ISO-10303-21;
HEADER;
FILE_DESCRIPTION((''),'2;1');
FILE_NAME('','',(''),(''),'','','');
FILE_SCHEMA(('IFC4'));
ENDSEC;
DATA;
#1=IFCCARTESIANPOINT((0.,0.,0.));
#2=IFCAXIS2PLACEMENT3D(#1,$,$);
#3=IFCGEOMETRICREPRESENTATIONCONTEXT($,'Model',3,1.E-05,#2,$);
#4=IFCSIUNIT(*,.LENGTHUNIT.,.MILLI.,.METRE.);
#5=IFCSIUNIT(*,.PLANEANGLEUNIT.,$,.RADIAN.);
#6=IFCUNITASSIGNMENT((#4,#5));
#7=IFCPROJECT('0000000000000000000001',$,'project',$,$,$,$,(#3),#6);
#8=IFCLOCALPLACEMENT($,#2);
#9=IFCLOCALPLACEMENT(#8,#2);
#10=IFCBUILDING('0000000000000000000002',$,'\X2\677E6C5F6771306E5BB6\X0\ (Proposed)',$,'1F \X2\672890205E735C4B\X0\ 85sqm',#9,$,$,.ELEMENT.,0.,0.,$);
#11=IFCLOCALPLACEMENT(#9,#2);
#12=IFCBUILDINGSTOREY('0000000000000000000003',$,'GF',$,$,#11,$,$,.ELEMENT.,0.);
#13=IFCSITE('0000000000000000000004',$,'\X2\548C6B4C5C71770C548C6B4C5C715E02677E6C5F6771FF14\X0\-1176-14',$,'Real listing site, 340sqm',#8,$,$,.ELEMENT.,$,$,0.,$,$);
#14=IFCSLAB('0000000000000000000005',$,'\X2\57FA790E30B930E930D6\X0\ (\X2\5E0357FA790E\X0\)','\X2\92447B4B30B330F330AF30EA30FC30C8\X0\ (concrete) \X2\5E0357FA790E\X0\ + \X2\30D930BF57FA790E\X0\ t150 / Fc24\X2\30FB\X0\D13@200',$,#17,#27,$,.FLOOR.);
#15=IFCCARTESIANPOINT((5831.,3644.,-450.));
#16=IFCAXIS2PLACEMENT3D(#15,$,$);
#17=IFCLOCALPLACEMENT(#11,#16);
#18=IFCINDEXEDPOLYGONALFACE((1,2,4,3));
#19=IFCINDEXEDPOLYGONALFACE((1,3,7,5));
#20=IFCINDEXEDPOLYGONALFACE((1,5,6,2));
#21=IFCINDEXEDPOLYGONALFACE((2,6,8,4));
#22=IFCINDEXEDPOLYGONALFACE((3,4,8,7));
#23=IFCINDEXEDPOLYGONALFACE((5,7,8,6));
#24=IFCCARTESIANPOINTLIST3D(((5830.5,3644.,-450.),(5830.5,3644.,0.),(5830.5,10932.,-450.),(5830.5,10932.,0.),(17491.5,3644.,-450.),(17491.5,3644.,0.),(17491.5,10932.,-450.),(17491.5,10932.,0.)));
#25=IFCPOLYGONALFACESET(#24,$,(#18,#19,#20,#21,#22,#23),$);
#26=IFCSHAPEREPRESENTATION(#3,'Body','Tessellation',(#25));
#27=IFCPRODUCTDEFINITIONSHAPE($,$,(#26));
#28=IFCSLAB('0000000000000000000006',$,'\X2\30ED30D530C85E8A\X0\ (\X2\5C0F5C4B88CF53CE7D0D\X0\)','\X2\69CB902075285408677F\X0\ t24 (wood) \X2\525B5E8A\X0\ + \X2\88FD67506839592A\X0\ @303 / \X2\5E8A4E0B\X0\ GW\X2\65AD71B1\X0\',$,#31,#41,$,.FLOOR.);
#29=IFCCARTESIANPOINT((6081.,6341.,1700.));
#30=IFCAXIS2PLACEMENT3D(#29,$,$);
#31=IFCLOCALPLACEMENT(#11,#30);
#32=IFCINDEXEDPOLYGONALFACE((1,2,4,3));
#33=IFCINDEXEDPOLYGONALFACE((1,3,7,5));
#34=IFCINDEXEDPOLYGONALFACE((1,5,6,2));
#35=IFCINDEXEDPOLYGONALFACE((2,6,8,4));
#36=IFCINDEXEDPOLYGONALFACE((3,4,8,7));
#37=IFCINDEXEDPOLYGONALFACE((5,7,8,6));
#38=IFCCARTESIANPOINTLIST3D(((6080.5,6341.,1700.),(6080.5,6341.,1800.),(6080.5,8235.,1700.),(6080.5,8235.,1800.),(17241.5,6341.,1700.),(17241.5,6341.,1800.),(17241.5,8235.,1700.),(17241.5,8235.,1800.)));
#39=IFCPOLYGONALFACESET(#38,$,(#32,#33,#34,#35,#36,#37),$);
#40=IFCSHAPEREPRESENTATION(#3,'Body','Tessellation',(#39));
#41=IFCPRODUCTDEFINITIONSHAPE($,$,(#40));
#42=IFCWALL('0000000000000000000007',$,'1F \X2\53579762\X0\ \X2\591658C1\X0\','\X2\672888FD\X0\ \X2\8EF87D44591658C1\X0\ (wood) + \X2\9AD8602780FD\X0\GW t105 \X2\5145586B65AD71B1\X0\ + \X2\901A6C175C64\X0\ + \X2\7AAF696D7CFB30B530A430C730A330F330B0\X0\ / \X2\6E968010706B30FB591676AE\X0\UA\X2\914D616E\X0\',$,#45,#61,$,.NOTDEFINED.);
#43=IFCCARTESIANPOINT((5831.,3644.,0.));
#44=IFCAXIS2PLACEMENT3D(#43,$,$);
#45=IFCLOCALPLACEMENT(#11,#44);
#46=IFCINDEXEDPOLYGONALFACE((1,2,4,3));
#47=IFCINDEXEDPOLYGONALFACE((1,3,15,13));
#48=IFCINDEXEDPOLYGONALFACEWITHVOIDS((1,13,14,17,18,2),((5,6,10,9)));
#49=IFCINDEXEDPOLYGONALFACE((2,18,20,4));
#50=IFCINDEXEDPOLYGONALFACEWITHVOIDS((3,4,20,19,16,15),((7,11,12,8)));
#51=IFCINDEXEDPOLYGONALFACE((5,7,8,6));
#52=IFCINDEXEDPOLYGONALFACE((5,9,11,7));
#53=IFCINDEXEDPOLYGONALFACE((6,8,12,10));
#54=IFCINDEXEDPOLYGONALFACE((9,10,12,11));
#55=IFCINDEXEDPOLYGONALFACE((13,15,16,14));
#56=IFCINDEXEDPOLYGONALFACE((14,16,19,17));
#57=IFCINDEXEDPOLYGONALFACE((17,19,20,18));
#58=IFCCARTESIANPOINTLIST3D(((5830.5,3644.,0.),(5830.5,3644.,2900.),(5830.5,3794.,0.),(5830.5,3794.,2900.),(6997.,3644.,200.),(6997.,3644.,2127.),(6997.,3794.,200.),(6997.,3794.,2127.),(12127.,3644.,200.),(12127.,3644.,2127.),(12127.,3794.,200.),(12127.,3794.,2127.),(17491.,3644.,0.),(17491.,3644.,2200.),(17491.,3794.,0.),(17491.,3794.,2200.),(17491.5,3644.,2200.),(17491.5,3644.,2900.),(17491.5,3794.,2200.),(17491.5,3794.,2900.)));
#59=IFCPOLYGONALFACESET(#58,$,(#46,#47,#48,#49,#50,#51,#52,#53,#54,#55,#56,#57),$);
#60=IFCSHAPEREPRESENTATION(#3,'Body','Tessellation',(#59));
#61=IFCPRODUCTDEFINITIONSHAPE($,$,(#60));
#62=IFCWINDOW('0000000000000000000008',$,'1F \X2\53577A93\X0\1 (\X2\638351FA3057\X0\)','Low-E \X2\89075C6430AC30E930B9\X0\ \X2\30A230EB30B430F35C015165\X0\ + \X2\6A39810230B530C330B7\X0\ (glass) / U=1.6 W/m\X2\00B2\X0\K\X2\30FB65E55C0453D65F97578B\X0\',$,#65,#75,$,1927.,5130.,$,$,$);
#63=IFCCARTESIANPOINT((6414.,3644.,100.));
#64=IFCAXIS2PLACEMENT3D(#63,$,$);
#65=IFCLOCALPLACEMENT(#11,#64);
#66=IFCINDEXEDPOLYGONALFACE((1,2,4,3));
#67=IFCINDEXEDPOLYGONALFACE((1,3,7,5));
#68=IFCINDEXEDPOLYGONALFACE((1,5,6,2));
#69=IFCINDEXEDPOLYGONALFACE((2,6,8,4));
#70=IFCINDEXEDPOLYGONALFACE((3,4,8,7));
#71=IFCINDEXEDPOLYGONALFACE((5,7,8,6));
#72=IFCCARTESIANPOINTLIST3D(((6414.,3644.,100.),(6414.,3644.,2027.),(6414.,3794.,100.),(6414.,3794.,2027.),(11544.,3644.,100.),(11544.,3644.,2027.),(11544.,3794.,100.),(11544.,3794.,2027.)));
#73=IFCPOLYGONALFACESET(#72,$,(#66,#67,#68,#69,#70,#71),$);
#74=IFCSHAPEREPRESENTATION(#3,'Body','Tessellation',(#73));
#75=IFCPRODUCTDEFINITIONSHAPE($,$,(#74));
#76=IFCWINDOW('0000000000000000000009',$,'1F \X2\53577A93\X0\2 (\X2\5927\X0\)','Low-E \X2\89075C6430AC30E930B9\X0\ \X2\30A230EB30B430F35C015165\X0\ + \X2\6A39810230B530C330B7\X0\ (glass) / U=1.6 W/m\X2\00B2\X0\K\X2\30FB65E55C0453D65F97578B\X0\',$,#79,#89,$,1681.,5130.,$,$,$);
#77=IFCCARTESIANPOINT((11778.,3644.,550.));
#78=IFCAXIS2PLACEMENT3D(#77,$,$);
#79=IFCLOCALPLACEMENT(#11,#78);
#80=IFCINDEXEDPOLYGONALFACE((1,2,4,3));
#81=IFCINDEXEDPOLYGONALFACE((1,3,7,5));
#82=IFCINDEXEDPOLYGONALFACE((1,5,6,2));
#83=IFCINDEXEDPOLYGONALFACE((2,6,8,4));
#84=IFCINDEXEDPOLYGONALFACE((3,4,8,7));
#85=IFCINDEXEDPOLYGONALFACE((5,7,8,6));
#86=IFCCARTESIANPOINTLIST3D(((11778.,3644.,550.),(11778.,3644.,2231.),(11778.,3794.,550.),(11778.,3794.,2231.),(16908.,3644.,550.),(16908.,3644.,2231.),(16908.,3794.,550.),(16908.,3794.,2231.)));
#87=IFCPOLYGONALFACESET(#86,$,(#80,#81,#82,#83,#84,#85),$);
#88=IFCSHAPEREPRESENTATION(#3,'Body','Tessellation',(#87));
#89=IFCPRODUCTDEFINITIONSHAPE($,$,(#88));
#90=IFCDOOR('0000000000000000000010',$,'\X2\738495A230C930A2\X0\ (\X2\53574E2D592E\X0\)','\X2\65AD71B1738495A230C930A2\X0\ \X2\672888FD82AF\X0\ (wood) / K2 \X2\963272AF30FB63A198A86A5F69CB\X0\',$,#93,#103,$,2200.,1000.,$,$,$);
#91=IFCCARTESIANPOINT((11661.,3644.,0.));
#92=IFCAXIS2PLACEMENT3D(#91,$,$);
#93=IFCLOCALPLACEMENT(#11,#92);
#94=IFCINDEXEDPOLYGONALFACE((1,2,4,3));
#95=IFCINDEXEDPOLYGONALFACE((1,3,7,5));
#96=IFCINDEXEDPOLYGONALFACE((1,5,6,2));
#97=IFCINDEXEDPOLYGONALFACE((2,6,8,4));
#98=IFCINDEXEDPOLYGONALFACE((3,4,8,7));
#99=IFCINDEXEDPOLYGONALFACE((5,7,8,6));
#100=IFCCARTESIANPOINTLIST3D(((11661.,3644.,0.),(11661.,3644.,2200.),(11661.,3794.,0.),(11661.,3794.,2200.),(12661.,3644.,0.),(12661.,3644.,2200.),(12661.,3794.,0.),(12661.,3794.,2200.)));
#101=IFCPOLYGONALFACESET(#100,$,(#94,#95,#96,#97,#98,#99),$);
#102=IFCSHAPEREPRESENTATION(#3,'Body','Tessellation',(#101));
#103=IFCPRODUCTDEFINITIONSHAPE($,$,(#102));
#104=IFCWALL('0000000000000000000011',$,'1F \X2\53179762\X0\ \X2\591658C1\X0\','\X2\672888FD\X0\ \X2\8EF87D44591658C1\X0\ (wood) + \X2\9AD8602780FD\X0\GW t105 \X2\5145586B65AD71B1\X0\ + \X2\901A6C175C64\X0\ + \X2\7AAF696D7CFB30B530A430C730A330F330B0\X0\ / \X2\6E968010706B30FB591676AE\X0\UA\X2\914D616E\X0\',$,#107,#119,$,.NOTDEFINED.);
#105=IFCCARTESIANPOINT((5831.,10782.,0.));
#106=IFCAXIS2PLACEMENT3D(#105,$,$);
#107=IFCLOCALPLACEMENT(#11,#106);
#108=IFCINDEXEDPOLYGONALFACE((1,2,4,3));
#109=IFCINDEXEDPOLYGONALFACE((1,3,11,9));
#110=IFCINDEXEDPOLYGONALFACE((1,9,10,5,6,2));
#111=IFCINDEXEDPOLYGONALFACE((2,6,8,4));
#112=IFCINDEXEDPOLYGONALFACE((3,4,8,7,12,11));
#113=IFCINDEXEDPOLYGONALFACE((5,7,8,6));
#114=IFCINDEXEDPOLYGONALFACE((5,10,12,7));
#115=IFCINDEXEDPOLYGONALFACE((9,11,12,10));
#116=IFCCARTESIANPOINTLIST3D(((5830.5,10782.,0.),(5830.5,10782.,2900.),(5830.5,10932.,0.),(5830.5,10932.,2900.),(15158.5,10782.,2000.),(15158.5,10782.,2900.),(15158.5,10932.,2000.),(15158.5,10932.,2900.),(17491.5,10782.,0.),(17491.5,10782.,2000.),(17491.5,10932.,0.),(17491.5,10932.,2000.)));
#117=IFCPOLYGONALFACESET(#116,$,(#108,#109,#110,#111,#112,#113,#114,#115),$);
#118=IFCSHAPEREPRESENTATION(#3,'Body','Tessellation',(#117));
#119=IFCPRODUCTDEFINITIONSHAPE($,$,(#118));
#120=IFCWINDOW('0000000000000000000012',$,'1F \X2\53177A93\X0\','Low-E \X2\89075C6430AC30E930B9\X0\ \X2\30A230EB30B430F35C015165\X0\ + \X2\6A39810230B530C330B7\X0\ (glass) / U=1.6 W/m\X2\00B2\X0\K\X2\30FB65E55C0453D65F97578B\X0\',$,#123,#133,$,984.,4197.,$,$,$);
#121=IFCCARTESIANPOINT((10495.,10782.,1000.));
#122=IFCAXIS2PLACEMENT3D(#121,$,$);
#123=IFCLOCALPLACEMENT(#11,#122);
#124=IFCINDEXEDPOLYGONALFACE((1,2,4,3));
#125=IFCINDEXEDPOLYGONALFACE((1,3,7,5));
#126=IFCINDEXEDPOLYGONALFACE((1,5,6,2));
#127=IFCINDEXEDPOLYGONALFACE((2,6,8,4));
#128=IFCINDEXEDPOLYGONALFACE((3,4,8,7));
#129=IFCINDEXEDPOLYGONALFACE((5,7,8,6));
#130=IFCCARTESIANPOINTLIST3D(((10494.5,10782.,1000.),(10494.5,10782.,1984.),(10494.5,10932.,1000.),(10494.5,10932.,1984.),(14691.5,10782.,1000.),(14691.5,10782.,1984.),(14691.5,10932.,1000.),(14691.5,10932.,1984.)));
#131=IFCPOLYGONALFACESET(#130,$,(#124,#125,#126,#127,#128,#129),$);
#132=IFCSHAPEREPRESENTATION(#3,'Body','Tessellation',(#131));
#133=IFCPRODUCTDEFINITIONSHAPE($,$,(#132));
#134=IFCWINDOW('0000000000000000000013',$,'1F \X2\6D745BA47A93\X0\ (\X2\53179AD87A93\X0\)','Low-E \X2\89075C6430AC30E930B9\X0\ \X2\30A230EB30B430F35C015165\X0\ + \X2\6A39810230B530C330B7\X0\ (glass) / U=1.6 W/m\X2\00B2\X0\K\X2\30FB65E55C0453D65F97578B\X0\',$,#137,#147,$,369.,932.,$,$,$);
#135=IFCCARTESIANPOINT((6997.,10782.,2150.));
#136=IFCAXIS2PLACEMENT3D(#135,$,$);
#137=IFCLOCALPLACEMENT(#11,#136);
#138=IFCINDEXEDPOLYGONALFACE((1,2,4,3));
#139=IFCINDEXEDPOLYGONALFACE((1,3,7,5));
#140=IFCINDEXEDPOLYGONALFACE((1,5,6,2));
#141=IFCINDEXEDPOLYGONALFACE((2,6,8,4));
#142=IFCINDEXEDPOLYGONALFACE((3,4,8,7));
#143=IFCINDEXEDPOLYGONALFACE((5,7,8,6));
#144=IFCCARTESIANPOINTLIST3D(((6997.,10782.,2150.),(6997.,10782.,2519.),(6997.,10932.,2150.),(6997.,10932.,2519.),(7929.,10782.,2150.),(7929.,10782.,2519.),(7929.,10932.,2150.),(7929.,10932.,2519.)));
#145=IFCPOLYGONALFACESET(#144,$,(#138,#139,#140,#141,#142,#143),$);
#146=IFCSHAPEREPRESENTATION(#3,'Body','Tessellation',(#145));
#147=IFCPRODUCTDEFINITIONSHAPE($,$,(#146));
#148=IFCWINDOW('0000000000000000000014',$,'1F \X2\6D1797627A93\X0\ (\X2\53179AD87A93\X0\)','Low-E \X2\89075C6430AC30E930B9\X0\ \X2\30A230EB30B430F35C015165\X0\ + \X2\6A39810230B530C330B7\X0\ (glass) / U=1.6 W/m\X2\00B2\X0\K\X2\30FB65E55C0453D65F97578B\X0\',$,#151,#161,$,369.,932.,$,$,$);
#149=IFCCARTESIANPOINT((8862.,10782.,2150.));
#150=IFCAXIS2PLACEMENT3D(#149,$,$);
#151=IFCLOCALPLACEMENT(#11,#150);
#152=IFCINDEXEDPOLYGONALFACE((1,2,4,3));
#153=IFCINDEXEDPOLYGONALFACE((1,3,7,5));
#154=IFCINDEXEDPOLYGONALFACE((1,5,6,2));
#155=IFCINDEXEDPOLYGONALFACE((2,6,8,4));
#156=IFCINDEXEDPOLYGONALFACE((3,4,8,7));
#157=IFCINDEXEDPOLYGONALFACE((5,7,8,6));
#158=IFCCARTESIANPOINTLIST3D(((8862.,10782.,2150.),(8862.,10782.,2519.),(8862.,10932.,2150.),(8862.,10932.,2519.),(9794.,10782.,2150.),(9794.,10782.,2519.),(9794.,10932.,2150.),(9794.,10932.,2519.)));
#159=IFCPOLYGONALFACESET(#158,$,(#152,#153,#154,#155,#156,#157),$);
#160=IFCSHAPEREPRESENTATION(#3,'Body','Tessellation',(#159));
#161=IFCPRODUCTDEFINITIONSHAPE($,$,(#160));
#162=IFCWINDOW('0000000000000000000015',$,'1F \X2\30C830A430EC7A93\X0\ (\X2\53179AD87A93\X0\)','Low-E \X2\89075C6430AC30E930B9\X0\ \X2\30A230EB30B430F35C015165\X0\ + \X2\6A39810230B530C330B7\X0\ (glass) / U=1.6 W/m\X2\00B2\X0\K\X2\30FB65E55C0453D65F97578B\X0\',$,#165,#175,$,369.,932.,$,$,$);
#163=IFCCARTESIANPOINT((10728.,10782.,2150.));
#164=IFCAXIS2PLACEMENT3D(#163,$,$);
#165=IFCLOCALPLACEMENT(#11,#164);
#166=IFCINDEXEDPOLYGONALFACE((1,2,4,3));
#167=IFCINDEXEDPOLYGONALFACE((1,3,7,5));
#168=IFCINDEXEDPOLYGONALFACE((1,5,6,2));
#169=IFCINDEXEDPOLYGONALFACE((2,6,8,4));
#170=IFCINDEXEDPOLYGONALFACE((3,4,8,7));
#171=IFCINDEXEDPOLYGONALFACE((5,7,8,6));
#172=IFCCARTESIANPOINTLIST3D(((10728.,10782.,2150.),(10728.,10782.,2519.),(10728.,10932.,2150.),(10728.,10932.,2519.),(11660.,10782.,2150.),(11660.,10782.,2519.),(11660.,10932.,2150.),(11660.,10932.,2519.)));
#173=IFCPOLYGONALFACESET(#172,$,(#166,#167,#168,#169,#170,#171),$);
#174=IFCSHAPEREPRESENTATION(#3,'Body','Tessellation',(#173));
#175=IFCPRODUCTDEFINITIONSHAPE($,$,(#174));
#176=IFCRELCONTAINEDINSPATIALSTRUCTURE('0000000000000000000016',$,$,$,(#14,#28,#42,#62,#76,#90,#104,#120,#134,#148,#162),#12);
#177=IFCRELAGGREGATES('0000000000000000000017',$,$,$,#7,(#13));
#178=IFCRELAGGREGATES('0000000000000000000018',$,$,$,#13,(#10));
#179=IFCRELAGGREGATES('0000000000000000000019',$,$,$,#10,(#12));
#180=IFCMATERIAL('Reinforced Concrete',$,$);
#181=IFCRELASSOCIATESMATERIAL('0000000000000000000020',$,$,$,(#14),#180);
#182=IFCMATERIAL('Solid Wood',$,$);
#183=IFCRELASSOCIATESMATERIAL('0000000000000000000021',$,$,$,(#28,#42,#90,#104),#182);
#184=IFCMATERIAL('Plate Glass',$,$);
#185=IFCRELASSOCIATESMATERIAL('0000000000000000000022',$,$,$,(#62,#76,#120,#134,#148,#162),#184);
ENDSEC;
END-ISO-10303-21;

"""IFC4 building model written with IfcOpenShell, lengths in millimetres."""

from ifc_helpers import new_model, si_unit, frame, frame_2d, origin, place, context, project, spatial, rectangle, extrude, material, element, fill, save


model = new_model("IFC4")

# Units and contexts
model_context = context("Model", 3, precision=1e-05, world=origin())
ifc_project = project(units=[si_unit("LENGTHUNIT", "METRE", prefix="MILLI"), si_unit("PLANEANGLEUNIT", "RADIAN")], contexts=[model_context])

# Site, building, storey
site_placement = place(None, origin())
site = spatial("IfcSite", under=ifc_project, at=site_placement, Name="和歌山県和歌山市松江東４-1176-14", ObjectType="Real listing site, 340sqm", CompositionType="ELEMENT", RefElevation=0.0)
building_placement = place(site_placement, origin())
building = spatial("IfcBuilding", under=site, at=building_placement, Name="松江東の家 (Proposed)", ObjectType="1F 木造平屋 85sqm", CompositionType="ELEMENT", ElevationOfRefHeight=0.0, ElevationOfTerrain=0.0)
storey_placement = place(building_placement, origin())
storey = spatial("IfcBuildingStorey", under=building, at=storey_placement, Name="GF", CompositionType="ELEMENT", Elevation=0.0)

# Slabs
ifc_material_1 = material(Name="Reinforced Concrete")
slab_1_placement = place(storey_placement, frame((5831.0, 3644.0, -450.0)))
element("IfcSlab", 1, at=slab_1_placement, inside=storey, material=ifc_material_1, Name="基礎スラブ (布基礎)", Description="鉄筋コンクリート (concrete) 布基礎 + ベタ基礎 t150 / Fc24・D13@200", PredefinedType="FLOOR", context=model_context, shape_type="SweptSolid", body=[
    extrude(rectangle(XDim=11661.0, YDim=7288.0, at=frame_2d((5830.0, 3644.0))), frame((5831.0, 3644.0, -450.0)), (0.0, 0.0, 1.0), 450.0),
])
ifc_material_2 = material(Name="Solid Wood")
slab_2_placement = place(storey_placement, frame((6081.0, 6341.0, 1700.0)))
element("IfcSlab", 2, at=slab_2_placement, inside=storey, material=ifc_material_2, Name="ロフト床 (小屋裏収納)", Description="構造用合板 t24 (wood) 剛床 + 製材根太 @303 / 床下 GW断熱", PredefinedType="FLOOR", context=model_context, shape_type="SweptSolid", body=[
    extrude(rectangle(XDim=11161.0, YDim=1894.0, at=frame_2d((5580.0, 947.0))), frame((6081.0, 6341.0, 1700.0)), (0.0, 0.0, 1.0), 100.0),
])

# Wall, openings, windows, door
wall_1_placement = place(storey_placement, frame((5831.0, 3644.0, 0.0)))
wall_1 = element("IfcWall", 3, at=wall_1_placement, inside=storey, material=ifc_material_2, Name="1F 南面 外壁", Description="木製 軸組外壁 (wood) + 高性能GW t105 充填断熱 + 通気層 + 窯業系サイディング / 準耐火・外皮UA配慮", PredefinedType="NOTDEFINED", context=model_context, shape_type="SweptSolid", body=[
    extrude(rectangle(XDim=11661.0, YDim=150.0, at=frame_2d((5830.0, 75.0))), frame((5831.0, 3644.0, 0.0)), (0.0, 0.0, 1.0), 2900.0),
])
opening_1_placement = place(storey_placement, frame((6414.0, 3644.0, 100.0)))
opening_1 = element("IfcOpeningElement", 4, at=opening_1_placement, cuts=wall_1, PredefinedType="NOTDEFINED", context=model_context, shape_type="SweptSolid", body=[
    extrude(rectangle(XDim=5130.0, YDim=150.0, at=frame_2d((2565.0, 75.0))), frame((6414.0, 3644.0, 100.0)), (0.0, 0.0, 1.0), 1927.0),
])
opening_2_placement = place(storey_placement, frame((11778.0, 3644.0, 550.0)))
opening_2 = element("IfcOpeningElement", 5, at=opening_2_placement, cuts=wall_1, PredefinedType="NOTDEFINED", context=model_context, shape_type="SweptSolid", body=[
    extrude(rectangle(XDim=5130.0, YDim=150.0, at=frame_2d((2565.0, 75.0))), frame((11778.0, 3644.0, 550.0)), (0.0, 0.0, 1.0), 1681.0),
])
opening_3_placement = place(storey_placement, frame((11661.0, 3644.0, 0.0)))
opening_3 = element("IfcOpeningElement", 6, at=opening_3_placement, cuts=wall_1, PredefinedType="NOTDEFINED", context=model_context, shape_type="SweptSolid", body=[
    extrude(rectangle(XDim=1000.0, YDim=150.0, at=frame_2d((500.0, 75.0))), frame((11661.0, 3644.0, 0.0)), (0.0, 0.0, 1.0), 2200.0),
])
ifc_material_3 = material(Name="Plate Glass")
window_1_placement = place(storey_placement, frame((6414.0, 3644.0, 100.0)))
window_1 = element("IfcWindow", 7, at=window_1_placement, inside=storey, material=ifc_material_3, Name="1F 南窓1 (掃出し)", Description="Low-E 複層ガラス アルゴン封入 + 樹脂サッシ (glass) / U=1.6 W/m²K・日射取得型", OverallHeight=1927.0, OverallWidth=5130.0, context=model_context, shape_type="SweptSolid", body=[
    extrude(rectangle(XDim=5130.0, YDim=150.0, at=frame_2d((2565.0, 75.0))), frame((6414.0, 3644.0, 100.0)), (0.0, 0.0, 1.0), 1927.0),
])
fill(opening_1, window_1)
window_2_placement = place(storey_placement, frame((11778.0, 3644.0, 550.0)))
window_2 = element("IfcWindow", 8, at=window_2_placement, inside=storey, material=ifc_material_3, Name="1F 南窓2 (大)", Description="Low-E 複層ガラス アルゴン封入 + 樹脂サッシ (glass) / U=1.6 W/m²K・日射取得型", OverallHeight=1681.0, OverallWidth=5130.0, context=model_context, shape_type="SweptSolid", body=[
    extrude(rectangle(XDim=5130.0, YDim=150.0, at=frame_2d((2565.0, 75.0))), frame((11778.0, 3644.0, 550.0)), (0.0, 0.0, 1.0), 1681.0),
])
fill(opening_2, window_2)
door_1_placement = place(storey_placement, frame((11661.0, 3644.0, 0.0)))
door_1 = element("IfcDoor", 9, at=door_1_placement, inside=storey, material=ifc_material_2, Name="玄関ドア (南中央)", Description="断熱玄関ドア 木製芯 (wood) / K2 防犯・採風機構", OverallHeight=2200.0, OverallWidth=1000.0, context=model_context, shape_type="SweptSolid", body=[
    extrude(rectangle(XDim=1000.0, YDim=150.0, at=frame_2d((500.0, 75.0))), frame((11661.0, 3644.0, 0.0)), (0.0, 0.0, 1.0), 2200.0),
])
fill(opening_3, door_1)

# Wall, openings, windows
wall_2_placement = place(storey_placement, frame((5831.0, 10782.0, 0.0)))
wall_2 = element("IfcWall", 10, at=wall_2_placement, inside=storey, material=ifc_material_2, Name="1F 北面 外壁", Description="木製 軸組外壁 (wood) + 高性能GW t105 充填断熱 + 通気層 + 窯業系サイディング / 準耐火・外皮UA配慮", PredefinedType="NOTDEFINED", context=model_context, shape_type="SweptSolid", body=[
    extrude(rectangle(XDim=11661.0, YDim=150.0, at=frame_2d((5830.0, 75.0))), frame((5831.0, 10782.0, 0.0)), (0.0, 0.0, 1.0), 2900.0),
])
opening_4_placement = place(storey_placement, frame((10495.0, 10782.0, 1000.0)))
opening_4 = element("IfcOpeningElement", 11, at=opening_4_placement, cuts=wall_2, PredefinedType="NOTDEFINED", context=model_context, shape_type="SweptSolid", body=[
    extrude(rectangle(XDim=4197.0, YDim=150.0, at=frame_2d((2098.0, 75.0))), frame((10495.0, 10782.0, 1000.0)), (0.0, 0.0, 1.0), 984.0),
])
opening_5_placement = place(storey_placement, frame((6997.0, 10782.0, 2150.0)))
opening_5 = element("IfcOpeningElement", 12, at=opening_5_placement, cuts=wall_2, PredefinedType="NOTDEFINED", context=model_context, shape_type="SweptSolid", body=[
    extrude(rectangle(XDim=932.0, YDim=150.0, at=frame_2d((466.0, 75.0))), frame((6997.0, 10782.0, 2150.0)), (0.0, 0.0, 1.0), 369.0),
])
opening_6_placement = place(storey_placement, frame((8862.0, 10782.0, 2150.0)))
opening_6 = element("IfcOpeningElement", 13, at=opening_6_placement, cuts=wall_2, PredefinedType="NOTDEFINED", context=model_context, shape_type="SweptSolid", body=[
    extrude(rectangle(XDim=932.0, YDim=150.0, at=frame_2d((466.0, 75.0))), frame((8862.0, 10782.0, 2150.0)), (0.0, 0.0, 1.0), 369.0),
])
opening_7_placement = place(storey_placement, frame((10728.0, 10782.0, 2150.0)))
opening_7 = element("IfcOpeningElement", 14, at=opening_7_placement, cuts=wall_2, PredefinedType="NOTDEFINED", context=model_context, shape_type="SweptSolid", body=[
    extrude(rectangle(XDim=932.0, YDim=150.0, at=frame_2d((466.0, 75.0))), frame((10728.0, 10782.0, 2150.0)), (0.0, 0.0, 1.0), 369.0),
])
window_3_placement = place(storey_placement, frame((10495.0, 10782.0, 1000.0)))
window_3 = element("IfcWindow", 15, at=window_3_placement, inside=storey, material=ifc_material_3, Name="1F 北窓", Description="Low-E 複層ガラス アルゴン封入 + 樹脂サッシ (glass) / U=1.6 W/m²K・日射取得型", OverallHeight=984.0, OverallWidth=4197.0, context=model_context, shape_type="SweptSolid", body=[
    extrude(rectangle(XDim=4197.0, YDim=150.0, at=frame_2d((2098.0, 75.0))), frame((10495.0, 10782.0, 1000.0)), (0.0, 0.0, 1.0), 984.0),
])
fill(opening_4, window_3)
window_4_placement = place(storey_placement, frame((6997.0, 10782.0, 2150.0)))
window_4 = element("IfcWindow", 16, at=window_4_placement, inside=storey, material=ifc_material_3, Name="1F 浴室窓 (北高窓)", Description="Low-E 複層ガラス アルゴン封入 + 樹脂サッシ (glass) / U=1.6 W/m²K・日射取得型", OverallHeight=369.0, OverallWidth=932.0, context=model_context, shape_type="SweptSolid", body=[
    extrude(rectangle(XDim=932.0, YDim=150.0, at=frame_2d((466.0, 75.0))), frame((6997.0, 10782.0, 2150.0)), (0.0, 0.0, 1.0), 369.0),
])
fill(opening_5, window_4)
window_5_placement = place(storey_placement, frame((8862.0, 10782.0, 2150.0)))
window_5 = element("IfcWindow", 17, at=window_5_placement, inside=storey, material=ifc_material_3, Name="1F 洗面窓 (北高窓)", Description="Low-E 複層ガラス アルゴン封入 + 樹脂サッシ (glass) / U=1.6 W/m²K・日射取得型", OverallHeight=369.0, OverallWidth=932.0, context=model_context, shape_type="SweptSolid", body=[
    extrude(rectangle(XDim=932.0, YDim=150.0, at=frame_2d((466.0, 75.0))), frame((8862.0, 10782.0, 2150.0)), (0.0, 0.0, 1.0), 369.0),
])
fill(opening_6, window_5)
window_6_placement = place(storey_placement, frame((10728.0, 10782.0, 2150.0)))
window_6 = element("IfcWindow", 18, at=window_6_placement, inside=storey, material=ifc_material_3, Name="1F トイレ窓 (北高窓)", Description="Low-E 複層ガラス アルゴン封入 + 樹脂サッシ (glass) / U=1.6 W/m²K・日射取得型", OverallHeight=369.0, OverallWidth=932.0, context=model_context, shape_type="SweptSolid", body=[
    extrude(rectangle(XDim=932.0, YDim=150.0, at=frame_2d((466.0, 75.0))), frame((10728.0, 10782.0, 2150.0)), (0.0, 0.0, 1.0), 369.0),
])
fill(opening_7, window_6)

save(model, "model.ifc")
